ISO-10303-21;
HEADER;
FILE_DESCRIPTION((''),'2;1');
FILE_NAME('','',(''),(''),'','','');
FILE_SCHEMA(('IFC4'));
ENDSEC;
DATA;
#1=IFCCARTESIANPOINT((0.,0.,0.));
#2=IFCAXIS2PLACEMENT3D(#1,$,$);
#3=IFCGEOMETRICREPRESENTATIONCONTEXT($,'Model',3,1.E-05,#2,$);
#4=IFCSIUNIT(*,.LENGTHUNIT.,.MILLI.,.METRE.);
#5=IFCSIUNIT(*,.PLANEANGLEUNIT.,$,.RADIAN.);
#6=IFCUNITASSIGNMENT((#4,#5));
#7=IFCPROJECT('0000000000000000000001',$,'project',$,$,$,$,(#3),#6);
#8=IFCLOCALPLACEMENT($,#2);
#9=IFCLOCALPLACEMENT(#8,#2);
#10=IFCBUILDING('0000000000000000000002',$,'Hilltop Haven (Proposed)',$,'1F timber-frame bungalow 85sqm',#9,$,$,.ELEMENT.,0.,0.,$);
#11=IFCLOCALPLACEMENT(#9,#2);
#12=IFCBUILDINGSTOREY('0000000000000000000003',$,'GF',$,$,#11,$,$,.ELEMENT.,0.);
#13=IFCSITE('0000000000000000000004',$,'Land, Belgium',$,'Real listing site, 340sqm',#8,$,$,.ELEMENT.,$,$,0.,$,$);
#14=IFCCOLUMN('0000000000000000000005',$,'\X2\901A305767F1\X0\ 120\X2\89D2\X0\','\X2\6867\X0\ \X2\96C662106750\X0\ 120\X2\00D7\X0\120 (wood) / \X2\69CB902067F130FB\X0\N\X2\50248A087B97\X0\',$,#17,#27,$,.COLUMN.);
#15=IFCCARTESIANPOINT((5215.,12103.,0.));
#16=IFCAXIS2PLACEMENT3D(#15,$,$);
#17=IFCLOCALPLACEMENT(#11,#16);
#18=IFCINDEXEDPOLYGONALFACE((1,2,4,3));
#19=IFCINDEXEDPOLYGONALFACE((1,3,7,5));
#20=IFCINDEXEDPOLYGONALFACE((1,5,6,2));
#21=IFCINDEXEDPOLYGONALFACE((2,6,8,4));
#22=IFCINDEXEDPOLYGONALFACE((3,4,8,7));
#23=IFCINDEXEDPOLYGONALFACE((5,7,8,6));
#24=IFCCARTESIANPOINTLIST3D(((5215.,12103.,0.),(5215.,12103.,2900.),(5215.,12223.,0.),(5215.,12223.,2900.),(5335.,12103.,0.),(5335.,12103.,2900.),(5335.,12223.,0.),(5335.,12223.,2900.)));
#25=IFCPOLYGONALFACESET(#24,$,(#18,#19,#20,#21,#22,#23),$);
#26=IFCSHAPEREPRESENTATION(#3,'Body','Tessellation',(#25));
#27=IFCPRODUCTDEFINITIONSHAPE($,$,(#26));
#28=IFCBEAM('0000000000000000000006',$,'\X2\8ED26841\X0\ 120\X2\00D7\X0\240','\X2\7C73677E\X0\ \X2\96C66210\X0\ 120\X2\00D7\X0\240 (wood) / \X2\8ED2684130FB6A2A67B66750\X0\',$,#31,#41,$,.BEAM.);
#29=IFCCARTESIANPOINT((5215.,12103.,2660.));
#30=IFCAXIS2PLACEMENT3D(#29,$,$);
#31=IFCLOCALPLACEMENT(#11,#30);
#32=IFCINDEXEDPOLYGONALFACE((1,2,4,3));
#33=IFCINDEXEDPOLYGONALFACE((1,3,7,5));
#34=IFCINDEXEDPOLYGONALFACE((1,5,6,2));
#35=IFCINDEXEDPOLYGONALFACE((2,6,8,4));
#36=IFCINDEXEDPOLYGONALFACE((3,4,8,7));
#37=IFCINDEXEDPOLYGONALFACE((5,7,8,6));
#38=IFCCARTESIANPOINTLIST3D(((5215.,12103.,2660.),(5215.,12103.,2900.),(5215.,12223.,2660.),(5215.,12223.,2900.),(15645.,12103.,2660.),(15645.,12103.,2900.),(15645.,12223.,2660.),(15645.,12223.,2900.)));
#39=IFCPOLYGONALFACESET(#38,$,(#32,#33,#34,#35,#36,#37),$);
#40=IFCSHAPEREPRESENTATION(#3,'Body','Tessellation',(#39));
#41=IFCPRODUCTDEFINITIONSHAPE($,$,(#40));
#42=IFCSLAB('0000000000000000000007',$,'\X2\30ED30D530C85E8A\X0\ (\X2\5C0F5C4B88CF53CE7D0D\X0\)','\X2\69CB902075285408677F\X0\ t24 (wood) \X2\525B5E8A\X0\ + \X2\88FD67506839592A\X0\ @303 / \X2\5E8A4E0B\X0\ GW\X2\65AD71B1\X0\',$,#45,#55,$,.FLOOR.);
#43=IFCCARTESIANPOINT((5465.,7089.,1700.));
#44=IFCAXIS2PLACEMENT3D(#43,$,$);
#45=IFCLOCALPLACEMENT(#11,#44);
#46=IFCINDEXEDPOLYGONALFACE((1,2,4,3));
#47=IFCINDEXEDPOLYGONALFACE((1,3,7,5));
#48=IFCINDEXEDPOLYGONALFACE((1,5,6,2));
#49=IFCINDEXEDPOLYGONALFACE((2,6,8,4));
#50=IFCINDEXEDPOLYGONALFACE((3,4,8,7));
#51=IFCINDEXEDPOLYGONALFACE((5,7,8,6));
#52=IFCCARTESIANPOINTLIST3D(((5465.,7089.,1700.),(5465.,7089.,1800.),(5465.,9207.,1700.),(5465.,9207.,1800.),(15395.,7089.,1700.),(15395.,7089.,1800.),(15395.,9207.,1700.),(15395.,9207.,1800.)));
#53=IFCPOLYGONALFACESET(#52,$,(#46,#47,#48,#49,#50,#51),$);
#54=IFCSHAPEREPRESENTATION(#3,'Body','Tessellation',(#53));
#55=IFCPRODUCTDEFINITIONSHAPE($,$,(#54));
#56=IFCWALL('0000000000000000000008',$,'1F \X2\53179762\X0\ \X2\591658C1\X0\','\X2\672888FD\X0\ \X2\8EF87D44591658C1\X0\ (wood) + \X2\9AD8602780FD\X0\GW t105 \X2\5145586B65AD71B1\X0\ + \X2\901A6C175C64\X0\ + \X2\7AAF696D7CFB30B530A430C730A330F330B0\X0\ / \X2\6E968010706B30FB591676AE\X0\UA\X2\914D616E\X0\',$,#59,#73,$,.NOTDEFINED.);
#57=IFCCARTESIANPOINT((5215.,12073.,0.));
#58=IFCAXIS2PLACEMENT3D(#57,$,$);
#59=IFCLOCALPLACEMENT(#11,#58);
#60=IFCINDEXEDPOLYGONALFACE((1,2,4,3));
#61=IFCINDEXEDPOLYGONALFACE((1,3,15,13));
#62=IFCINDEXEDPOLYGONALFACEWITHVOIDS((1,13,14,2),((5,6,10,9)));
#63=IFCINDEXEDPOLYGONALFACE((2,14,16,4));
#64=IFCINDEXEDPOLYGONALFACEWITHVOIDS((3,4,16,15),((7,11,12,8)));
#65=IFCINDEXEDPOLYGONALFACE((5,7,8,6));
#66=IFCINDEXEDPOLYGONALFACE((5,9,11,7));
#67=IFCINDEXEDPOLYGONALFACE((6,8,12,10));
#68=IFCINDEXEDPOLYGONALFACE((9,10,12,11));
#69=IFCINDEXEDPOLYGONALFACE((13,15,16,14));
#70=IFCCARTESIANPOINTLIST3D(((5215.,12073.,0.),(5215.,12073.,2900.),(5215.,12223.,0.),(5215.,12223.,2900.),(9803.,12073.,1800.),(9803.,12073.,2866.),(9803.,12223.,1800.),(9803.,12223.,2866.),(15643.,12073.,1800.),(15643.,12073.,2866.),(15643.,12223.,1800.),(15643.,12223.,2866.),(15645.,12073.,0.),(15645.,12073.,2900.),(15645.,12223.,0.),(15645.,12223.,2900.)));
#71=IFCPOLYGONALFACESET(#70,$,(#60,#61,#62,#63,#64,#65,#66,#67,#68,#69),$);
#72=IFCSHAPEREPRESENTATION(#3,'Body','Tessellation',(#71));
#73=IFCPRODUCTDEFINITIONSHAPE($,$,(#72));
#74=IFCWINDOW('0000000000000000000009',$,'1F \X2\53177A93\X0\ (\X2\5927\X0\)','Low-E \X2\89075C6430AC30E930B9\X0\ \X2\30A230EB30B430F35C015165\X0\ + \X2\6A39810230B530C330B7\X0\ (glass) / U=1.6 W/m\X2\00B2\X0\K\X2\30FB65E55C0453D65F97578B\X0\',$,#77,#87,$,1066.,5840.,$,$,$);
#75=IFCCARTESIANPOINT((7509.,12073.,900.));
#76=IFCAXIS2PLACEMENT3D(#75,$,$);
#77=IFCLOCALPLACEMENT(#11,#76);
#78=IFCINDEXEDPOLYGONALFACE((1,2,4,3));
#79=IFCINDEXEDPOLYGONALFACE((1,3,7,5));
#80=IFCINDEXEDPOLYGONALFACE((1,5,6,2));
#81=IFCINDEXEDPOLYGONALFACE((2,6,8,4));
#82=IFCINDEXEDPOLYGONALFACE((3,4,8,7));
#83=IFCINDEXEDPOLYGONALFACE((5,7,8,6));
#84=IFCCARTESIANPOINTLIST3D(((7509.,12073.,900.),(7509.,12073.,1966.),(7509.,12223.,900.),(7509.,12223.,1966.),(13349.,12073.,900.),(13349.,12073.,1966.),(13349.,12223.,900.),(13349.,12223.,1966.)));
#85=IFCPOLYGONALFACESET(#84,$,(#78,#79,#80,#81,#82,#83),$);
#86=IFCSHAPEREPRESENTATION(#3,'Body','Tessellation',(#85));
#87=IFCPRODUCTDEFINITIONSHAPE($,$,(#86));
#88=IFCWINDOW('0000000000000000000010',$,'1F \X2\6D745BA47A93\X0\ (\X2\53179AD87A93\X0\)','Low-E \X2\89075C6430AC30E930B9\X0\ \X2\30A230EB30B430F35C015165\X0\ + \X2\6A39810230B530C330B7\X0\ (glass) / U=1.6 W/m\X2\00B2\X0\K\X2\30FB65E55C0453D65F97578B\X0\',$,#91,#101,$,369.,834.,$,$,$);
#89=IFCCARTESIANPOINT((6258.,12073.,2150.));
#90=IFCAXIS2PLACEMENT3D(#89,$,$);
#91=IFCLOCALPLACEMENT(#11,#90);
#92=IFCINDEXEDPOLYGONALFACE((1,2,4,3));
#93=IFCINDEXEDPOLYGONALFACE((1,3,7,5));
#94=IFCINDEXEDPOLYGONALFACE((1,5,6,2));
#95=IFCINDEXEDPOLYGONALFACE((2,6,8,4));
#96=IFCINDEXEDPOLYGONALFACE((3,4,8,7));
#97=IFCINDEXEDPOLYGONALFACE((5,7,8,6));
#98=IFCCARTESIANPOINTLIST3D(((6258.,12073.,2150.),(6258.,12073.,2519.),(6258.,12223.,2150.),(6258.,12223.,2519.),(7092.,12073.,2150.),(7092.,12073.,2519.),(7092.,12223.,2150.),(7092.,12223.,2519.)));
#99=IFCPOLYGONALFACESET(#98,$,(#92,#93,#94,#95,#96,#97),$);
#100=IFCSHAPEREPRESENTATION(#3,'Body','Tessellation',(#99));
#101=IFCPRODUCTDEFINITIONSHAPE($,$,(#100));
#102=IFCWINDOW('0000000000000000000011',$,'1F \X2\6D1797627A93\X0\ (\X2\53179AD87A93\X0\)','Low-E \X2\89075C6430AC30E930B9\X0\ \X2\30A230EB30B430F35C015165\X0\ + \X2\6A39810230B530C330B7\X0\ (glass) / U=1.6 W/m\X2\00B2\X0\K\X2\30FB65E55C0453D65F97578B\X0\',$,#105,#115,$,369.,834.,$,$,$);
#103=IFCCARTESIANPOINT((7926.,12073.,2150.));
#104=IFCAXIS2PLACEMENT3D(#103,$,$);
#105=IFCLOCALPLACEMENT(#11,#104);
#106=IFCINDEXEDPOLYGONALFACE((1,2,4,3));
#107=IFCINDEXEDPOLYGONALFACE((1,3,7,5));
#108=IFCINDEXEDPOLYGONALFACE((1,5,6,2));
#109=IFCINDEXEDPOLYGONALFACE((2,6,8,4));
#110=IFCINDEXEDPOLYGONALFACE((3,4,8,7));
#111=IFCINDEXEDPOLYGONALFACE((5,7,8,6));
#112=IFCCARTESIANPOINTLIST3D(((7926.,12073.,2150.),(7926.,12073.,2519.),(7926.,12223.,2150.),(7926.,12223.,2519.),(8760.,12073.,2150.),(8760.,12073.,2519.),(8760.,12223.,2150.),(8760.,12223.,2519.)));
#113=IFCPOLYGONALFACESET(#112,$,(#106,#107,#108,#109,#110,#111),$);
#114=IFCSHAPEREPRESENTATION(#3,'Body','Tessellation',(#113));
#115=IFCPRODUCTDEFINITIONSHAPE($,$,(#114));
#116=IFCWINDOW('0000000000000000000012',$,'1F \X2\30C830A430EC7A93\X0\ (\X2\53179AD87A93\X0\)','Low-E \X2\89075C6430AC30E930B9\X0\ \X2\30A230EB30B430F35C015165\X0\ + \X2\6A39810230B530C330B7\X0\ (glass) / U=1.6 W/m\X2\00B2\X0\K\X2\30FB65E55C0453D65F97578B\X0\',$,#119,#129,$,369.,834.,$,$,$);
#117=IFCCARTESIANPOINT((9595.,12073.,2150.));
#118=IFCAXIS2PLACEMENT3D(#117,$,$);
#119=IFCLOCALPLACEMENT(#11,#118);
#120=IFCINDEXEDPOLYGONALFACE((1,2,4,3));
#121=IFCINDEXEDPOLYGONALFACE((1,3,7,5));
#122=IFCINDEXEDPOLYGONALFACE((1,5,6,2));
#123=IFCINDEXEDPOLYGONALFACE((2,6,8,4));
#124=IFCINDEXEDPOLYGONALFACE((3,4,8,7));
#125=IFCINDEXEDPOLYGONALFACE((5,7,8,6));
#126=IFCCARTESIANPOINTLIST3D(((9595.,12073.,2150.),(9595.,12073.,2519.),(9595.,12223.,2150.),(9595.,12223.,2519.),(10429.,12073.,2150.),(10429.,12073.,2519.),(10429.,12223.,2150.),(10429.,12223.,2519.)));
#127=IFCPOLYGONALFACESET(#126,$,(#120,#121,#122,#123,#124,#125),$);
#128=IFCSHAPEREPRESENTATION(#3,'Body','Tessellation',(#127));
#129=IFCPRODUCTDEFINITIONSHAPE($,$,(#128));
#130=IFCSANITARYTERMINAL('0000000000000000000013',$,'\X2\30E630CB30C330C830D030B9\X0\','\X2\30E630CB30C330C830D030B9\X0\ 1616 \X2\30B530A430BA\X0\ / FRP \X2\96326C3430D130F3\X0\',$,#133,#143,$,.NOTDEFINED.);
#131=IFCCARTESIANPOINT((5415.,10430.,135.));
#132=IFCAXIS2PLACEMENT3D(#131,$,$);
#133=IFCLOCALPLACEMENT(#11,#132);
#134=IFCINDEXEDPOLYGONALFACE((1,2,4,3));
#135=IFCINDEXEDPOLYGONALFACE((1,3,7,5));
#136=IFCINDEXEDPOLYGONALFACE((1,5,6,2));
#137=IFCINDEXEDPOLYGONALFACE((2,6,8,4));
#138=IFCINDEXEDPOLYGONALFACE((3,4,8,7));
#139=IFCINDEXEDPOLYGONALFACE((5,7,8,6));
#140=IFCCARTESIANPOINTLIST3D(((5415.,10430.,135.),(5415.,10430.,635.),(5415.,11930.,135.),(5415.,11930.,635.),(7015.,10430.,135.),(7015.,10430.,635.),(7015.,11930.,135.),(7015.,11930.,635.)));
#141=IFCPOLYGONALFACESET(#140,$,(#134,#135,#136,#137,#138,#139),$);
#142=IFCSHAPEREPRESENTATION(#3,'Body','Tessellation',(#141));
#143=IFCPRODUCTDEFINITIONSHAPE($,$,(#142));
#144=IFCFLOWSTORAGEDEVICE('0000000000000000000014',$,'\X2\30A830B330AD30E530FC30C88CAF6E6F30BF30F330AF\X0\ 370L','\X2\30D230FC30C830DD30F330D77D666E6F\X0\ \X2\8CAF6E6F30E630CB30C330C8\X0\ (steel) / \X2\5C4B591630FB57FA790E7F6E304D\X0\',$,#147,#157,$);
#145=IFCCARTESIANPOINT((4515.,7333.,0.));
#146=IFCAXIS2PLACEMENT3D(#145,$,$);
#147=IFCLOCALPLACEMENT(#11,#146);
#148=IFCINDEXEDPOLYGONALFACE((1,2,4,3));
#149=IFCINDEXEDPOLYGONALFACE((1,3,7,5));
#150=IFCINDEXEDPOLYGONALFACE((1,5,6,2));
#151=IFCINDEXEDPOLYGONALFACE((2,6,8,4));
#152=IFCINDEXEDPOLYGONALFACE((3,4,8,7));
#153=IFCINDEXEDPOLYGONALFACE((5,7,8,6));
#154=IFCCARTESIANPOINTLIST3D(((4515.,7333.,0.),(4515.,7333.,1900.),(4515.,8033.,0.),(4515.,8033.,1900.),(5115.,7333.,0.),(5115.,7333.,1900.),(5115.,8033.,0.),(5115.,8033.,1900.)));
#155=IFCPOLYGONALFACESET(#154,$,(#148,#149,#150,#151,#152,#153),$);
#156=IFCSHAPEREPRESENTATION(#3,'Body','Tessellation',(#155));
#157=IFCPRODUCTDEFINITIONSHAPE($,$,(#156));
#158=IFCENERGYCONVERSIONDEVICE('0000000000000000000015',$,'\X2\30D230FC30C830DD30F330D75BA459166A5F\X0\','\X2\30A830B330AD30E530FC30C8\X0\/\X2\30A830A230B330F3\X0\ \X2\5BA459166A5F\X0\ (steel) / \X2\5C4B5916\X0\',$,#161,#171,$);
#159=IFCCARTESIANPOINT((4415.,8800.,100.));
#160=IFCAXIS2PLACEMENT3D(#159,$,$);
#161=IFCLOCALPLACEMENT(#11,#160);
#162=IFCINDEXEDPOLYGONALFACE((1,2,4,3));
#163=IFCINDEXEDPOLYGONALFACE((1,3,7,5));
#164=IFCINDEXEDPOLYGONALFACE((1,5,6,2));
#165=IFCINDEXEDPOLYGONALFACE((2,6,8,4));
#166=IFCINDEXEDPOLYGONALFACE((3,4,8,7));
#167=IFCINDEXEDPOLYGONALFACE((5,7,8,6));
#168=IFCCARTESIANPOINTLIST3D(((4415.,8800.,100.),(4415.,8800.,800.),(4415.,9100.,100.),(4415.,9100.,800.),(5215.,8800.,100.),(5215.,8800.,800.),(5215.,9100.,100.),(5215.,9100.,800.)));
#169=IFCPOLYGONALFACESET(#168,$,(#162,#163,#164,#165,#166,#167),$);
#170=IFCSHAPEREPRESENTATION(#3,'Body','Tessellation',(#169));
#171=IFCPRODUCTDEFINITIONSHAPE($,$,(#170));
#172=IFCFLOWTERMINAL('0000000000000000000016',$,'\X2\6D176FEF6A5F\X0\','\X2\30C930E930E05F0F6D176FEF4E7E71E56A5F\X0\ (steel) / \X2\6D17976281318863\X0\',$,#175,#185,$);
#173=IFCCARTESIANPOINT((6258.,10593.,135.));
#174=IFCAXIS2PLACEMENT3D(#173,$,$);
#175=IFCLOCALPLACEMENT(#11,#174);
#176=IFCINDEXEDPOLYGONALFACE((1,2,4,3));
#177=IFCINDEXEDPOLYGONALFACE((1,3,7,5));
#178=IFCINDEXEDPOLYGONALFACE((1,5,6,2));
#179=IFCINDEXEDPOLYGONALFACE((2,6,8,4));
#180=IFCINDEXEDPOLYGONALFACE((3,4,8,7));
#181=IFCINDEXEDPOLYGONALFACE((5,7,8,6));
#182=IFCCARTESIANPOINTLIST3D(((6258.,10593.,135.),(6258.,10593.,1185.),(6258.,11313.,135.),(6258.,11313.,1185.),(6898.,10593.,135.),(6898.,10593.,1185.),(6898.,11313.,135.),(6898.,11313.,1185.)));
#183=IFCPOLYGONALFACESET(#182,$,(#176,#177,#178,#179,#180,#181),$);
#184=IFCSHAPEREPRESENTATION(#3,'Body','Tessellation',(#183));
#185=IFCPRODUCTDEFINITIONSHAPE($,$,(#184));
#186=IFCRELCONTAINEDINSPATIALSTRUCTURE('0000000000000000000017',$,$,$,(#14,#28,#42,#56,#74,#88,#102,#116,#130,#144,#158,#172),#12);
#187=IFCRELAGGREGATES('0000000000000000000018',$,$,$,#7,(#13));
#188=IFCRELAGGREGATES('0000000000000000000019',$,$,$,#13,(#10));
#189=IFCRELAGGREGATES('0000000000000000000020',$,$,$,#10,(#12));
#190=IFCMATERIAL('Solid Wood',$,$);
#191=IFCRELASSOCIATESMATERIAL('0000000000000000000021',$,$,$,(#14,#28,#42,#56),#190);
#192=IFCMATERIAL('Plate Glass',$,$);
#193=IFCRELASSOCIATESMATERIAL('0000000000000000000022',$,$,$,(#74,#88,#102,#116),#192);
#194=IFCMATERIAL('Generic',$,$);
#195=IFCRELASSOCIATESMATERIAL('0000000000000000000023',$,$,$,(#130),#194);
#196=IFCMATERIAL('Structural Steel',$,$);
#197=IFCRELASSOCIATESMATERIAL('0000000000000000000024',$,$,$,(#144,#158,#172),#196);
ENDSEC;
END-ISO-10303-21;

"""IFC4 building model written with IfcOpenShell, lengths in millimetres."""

from ifc_helpers import new_model, si_unit, frame, frame_2d, origin, place, context, project, spatial, rectangle, extrude, material, element, fill, save


model = new_model("IFC4")

# Units and contexts
model_context = context("Model", 3, precision=1e-05, world=origin())
ifc_project = project(units=[si_unit("LENGTHUNIT", "METRE", prefix="MILLI"), si_unit("PLANEANGLEUNIT", "RADIAN")], contexts=[model_context])

# Site, building, storey
site_placement = place(None, origin())
site = spatial("IfcSite", under=ifc_project, at=site_placement, Name="Land, Belgium", ObjectType="Real listing site, 340sqm", CompositionType="ELEMENT", RefElevation=0.0)
building_placement = place(site_placement, origin())
building = spatial("IfcBuilding", under=site, at=building_placement, Name="Hilltop Haven (Proposed)", ObjectType="1F timber-frame bungalow 85sqm", CompositionType="ELEMENT", ElevationOfRefHeight=0.0, ElevationOfTerrain=0.0)
storey_placement = place(building_placement, origin())
storey = spatial("IfcBuildingStorey", under=building, at=storey_placement, Name="GF", CompositionType="ELEMENT", Elevation=0.0)

# Column
ifc_material_1 = material(Name="Solid Wood")
column_1_placement = place(storey_placement, frame((5215.0, 12103.0, 0.0)))
element("IfcColumn", 1, at=column_1_placement, inside=storey, material=ifc_material_1, Name="通し柱 120角", Description="桧 集成材 120×120 (wood) / 構造柱・N値計算", PredefinedType="COLUMN", context=model_context, shape_type="SweptSolid", body=[
    extrude(rectangle(XDim=120.0, YDim=120.0, at=frame_2d((60.0, 60.0))), frame((5215.0, 12103.0, 0.0)), (0.0, 0.0, 1.0), 2900.0),
])

# Beam
beam_1_placement = place(storey_placement, frame((5215.0, 12103.0, 2660.0)))
element("IfcBeam", 2, at=beam_1_placement, inside=storey, material=ifc_material_1, Name="軒桁 120×240", Description="米松 集成 120×240 (wood) / 軒桁・横架材", PredefinedType="BEAM", context=model_context, shape_type="SweptSolid", body=[
    extrude(rectangle(XDim=10430.0, YDim=120.0, at=frame_2d((5215.0, 60.0))), frame((5215.0, 12103.0, 2660.0)), (0.0, 0.0, 1.0), 240.0),
])

# Slab
slab_placement = place(storey_placement, frame((5465.0, 7089.0, 1700.0)))
element("IfcSlab", 3, at=slab_placement, inside=storey, material=ifc_material_1, Name="ロフト床 (小屋裏収納)", Description="構造用合板 t24 (wood) 剛床 + 製材根太 @303 / 床下 GW断熱", PredefinedType="FLOOR", context=model_context, shape_type="SweptSolid", body=[
    extrude(rectangle(XDim=9930.0, YDim=2118.0, at=frame_2d((4965.0, 1059.0))), frame((5465.0, 7089.0, 1700.0)), (0.0, 0.0, 1.0), 100.0),
])

# Wall, openings, windows
wall_1_placement = place(storey_placement, frame((5215.0, 12073.0, 0.0)))
wall_1 = element("IfcWall", 4, at=wall_1_placement, inside=storey, material=ifc_material_1, Name="1F 北面 外壁", Description="木製 軸組外壁 (wood) + 高性能GW t105 充填断熱 + 通気層 + 窯業系サイディング / 準耐火・外皮UA配慮", PredefinedType="NOTDEFINED", context=model_context, shape_type="SweptSolid", body=[
    extrude(rectangle(XDim=10430.0, YDim=150.0, at=frame_2d((5215.0, 75.0))), frame((5215.0, 12073.0, 0.0)), (0.0, 0.0, 1.0), 2900.0),
])
opening_1_placement = place(storey_placement, frame((7509.0, 12073.0, 900.0)))
opening_1 = element("IfcOpeningElement", 5, at=opening_1_placement, cuts=wall_1, PredefinedType="NOTDEFINED", context=model_context, shape_type="SweptSolid", body=[
    extrude(rectangle(XDim=5840.0, YDim=150.0, at=frame_2d((2920.0, 75.0))), frame((7509.0, 12073.0, 900.0)), (0.0, 0.0, 1.0), 1066.0),
])
opening_2_placement = place(storey_placement, frame((6258.0, 12073.0, 2150.0)))
opening_2 = element("IfcOpeningElement", 6, at=opening_2_placement, cuts=wall_1, PredefinedType="NOTDEFINED", context=model_context, shape_type="SweptSolid", body=[
    extrude(rectangle(XDim=834.0, YDim=150.0, at=frame_2d((417.0, 75.0))), frame((6258.0, 12073.0, 2150.0)), (0.0, 0.0, 1.0), 369.0),
])
opening_3_placement = place(storey_placement, frame((7926.0, 12073.0, 2150.0)))
opening_3 = element("IfcOpeningElement", 7, at=opening_3_placement, cuts=wall_1, PredefinedType="NOTDEFINED", context=model_context, shape_type="SweptSolid", body=[
    extrude(rectangle(XDim=834.0, YDim=150.0, at=frame_2d((417.0, 75.0))), frame((7926.0, 12073.0, 2150.0)), (0.0, 0.0, 1.0), 369.0),
])
opening_4_placement = place(storey_placement, frame((9595.0, 12073.0, 2150.0)))
opening_4 = element("IfcOpeningElement", 8, at=opening_4_placement, cuts=wall_1, PredefinedType="NOTDEFINED", context=model_context, shape_type="SweptSolid", body=[
    extrude(rectangle(XDim=834.0, YDim=150.0, at=frame_2d((417.0, 75.0))), frame((9595.0, 12073.0, 2150.0)), (0.0, 0.0, 1.0), 369.0),
])
ifc_material_2 = material(Name="Plate Glass")
window_1_placement = place(storey_placement, frame((7509.0, 12073.0, 900.0)))
window_1 = element("IfcWindow", 9, at=window_1_placement, inside=storey, material=ifc_material_2, Name="1F 北窓 (大)", Description="Low-E 複層ガラス アルゴン封入 + 樹脂サッシ (glass) / U=1.6 W/m²K・日射取得型", OverallHeight=1066.0, OverallWidth=5840.0, context=model_context, shape_type="SweptSolid", body=[
    extrude(rectangle(XDim=5840.0, YDim=150.0, at=frame_2d((2920.0, 75.0))), frame((7509.0, 12073.0, 900.0)), (0.0, 0.0, 1.0), 1066.0),
])
fill(opening_1, window_1)
window_2_placement = place(storey_placement, frame((6258.0, 12073.0, 2150.0)))
window_2 = element("IfcWindow", 10, at=window_2_placement, inside=storey, material=ifc_material_2, Name="1F 浴室窓 (北高窓)", Description="Low-E 複層ガラス アルゴン封入 + 樹脂サッシ (glass) / U=1.6 W/m²K・日射取得型", OverallHeight=369.0, OverallWidth=834.0, context=model_context, shape_type="SweptSolid", body=[
    extrude(rectangle(XDim=834.0, YDim=150.0, at=frame_2d((417.0, 75.0))), frame((6258.0, 12073.0, 2150.0)), (0.0, 0.0, 1.0), 369.0),
])
fill(opening_2, window_2)
window_3_placement = place(storey_placement, frame((7926.0, 12073.0, 2150.0)))
window_3 = element("IfcWindow", 11, at=window_3_placement, inside=storey, material=ifc_material_2, Name="1F 洗面窓 (北高窓)", Description="Low-E 複層ガラス アルゴン封入 + 樹脂サッシ (glass) / U=1.6 W/m²K・日射取得型", OverallHeight=369.0, OverallWidth=834.0, context=model_context, shape_type="SweptSolid", body=[
    extrude(rectangle(XDim=834.0, YDim=150.0, at=frame_2d((417.0, 75.0))), frame((7926.0, 12073.0, 2150.0)), (0.0, 0.0, 1.0), 369.0),
])
fill(opening_3, window_3)
window_4_placement = place(storey_placement, frame((9595.0, 12073.0, 2150.0)))
window_4 = element("IfcWindow", 12, at=window_4_placement, inside=storey, material=ifc_material_2, Name="1F トイレ窓 (北高窓)", Description="Low-E 複層ガラス アルゴン封入 + 樹脂サッシ (glass) / U=1.6 W/m²K・日射取得型", OverallHeight=369.0, OverallWidth=834.0, context=model_context, shape_type="SweptSolid", body=[
    extrude(rectangle(XDim=834.0, YDim=150.0, at=frame_2d((417.0, 75.0))), frame((9595.0, 12073.0, 2150.0)), (0.0, 0.0, 1.0), 369.0),
])
fill(opening_4, window_4)

# Sanitary terminal
ifc_material_3 = material(Name="Generic")
sanitary_terminal_placement = place(storey_placement, frame((5415.0, 10430.0, 135.0)))
element("IfcSanitaryTerminal", 13, at=sanitary_terminal_placement, inside=storey, material=ifc_material_3, Name="ユニットバス", Description="ユニットバス 1616 サイズ / FRP 防水パン", PredefinedType="NOTDEFINED", context=model_context, shape_type="SweptSolid", body=[
    extrude(rectangle(XDim=1600.0, YDim=1500.0, at=frame_2d((800.0, 750.0))), frame((5415.0, 10430.0, 135.0)), (0.0, 0.0, 1.0), 500.0),
])

# Flow storage device
ifc_material_4 = material(Name="Structural Steel")
flow_storage_device_placement = place(storey_placement, frame((4515.0, 7333.0, 0.0)))
element("IfcFlowStorageDevice", 14, at=flow_storage_device_placement, inside=storey, material=ifc_material_4, Name="エコキュート貯湯タンク 370L", Description="ヒートポンプ給湯 貯湯ユニット (steel) / 屋外・基礎置き", context=model_context, shape_type="SweptSolid", body=[
    extrude(rectangle(XDim=600.0, YDim=700.0, at=frame_2d((300.0, 350.0))), frame((4515.0, 7333.0, 0.0)), (0.0, 0.0, 1.0), 1900.0),
])

# Energy conversion device
energy_conversion_device_placement = place(storey_placement, frame((4415.0, 8800.0, 100.0)))
element("IfcEnergyConversionDevice", 15, at=energy_conversion_device_placement, inside=storey, material=ifc_material_4, Name="ヒートポンプ室外機", Description="エコキュート/エアコン 室外機 (steel) / 屋外", context=model_context, shape_type="SweptSolid", body=[
    extrude(rectangle(XDim=800.0, YDim=300.0, at=frame_2d((400.0, 150.0))), frame((4415.0, 8800.0, 100.0)), (0.0, 0.0, 1.0), 700.0),
])

# Flow terminal
flow_terminal_placement = place(storey_placement, frame((6258.0, 10593.0, 135.0)))
element("IfcFlowTerminal", 16, at=flow_terminal_placement, inside=storey, material=ifc_material_4, Name="洗濯機", Description="ドラム式洗濯乾燥機 (steel) / 洗面脱衣", context=model_context, shape_type="SweptSolid", body=[
    extrude(rectangle(XDim=640.0, YDim=720.0, at=frame_2d((320.0, 360.0))), frame((6258.0, 10593.0, 135.0)), (0.0, 0.0, 1.0), 1050.0),
])

save(model, "model.ifc")
